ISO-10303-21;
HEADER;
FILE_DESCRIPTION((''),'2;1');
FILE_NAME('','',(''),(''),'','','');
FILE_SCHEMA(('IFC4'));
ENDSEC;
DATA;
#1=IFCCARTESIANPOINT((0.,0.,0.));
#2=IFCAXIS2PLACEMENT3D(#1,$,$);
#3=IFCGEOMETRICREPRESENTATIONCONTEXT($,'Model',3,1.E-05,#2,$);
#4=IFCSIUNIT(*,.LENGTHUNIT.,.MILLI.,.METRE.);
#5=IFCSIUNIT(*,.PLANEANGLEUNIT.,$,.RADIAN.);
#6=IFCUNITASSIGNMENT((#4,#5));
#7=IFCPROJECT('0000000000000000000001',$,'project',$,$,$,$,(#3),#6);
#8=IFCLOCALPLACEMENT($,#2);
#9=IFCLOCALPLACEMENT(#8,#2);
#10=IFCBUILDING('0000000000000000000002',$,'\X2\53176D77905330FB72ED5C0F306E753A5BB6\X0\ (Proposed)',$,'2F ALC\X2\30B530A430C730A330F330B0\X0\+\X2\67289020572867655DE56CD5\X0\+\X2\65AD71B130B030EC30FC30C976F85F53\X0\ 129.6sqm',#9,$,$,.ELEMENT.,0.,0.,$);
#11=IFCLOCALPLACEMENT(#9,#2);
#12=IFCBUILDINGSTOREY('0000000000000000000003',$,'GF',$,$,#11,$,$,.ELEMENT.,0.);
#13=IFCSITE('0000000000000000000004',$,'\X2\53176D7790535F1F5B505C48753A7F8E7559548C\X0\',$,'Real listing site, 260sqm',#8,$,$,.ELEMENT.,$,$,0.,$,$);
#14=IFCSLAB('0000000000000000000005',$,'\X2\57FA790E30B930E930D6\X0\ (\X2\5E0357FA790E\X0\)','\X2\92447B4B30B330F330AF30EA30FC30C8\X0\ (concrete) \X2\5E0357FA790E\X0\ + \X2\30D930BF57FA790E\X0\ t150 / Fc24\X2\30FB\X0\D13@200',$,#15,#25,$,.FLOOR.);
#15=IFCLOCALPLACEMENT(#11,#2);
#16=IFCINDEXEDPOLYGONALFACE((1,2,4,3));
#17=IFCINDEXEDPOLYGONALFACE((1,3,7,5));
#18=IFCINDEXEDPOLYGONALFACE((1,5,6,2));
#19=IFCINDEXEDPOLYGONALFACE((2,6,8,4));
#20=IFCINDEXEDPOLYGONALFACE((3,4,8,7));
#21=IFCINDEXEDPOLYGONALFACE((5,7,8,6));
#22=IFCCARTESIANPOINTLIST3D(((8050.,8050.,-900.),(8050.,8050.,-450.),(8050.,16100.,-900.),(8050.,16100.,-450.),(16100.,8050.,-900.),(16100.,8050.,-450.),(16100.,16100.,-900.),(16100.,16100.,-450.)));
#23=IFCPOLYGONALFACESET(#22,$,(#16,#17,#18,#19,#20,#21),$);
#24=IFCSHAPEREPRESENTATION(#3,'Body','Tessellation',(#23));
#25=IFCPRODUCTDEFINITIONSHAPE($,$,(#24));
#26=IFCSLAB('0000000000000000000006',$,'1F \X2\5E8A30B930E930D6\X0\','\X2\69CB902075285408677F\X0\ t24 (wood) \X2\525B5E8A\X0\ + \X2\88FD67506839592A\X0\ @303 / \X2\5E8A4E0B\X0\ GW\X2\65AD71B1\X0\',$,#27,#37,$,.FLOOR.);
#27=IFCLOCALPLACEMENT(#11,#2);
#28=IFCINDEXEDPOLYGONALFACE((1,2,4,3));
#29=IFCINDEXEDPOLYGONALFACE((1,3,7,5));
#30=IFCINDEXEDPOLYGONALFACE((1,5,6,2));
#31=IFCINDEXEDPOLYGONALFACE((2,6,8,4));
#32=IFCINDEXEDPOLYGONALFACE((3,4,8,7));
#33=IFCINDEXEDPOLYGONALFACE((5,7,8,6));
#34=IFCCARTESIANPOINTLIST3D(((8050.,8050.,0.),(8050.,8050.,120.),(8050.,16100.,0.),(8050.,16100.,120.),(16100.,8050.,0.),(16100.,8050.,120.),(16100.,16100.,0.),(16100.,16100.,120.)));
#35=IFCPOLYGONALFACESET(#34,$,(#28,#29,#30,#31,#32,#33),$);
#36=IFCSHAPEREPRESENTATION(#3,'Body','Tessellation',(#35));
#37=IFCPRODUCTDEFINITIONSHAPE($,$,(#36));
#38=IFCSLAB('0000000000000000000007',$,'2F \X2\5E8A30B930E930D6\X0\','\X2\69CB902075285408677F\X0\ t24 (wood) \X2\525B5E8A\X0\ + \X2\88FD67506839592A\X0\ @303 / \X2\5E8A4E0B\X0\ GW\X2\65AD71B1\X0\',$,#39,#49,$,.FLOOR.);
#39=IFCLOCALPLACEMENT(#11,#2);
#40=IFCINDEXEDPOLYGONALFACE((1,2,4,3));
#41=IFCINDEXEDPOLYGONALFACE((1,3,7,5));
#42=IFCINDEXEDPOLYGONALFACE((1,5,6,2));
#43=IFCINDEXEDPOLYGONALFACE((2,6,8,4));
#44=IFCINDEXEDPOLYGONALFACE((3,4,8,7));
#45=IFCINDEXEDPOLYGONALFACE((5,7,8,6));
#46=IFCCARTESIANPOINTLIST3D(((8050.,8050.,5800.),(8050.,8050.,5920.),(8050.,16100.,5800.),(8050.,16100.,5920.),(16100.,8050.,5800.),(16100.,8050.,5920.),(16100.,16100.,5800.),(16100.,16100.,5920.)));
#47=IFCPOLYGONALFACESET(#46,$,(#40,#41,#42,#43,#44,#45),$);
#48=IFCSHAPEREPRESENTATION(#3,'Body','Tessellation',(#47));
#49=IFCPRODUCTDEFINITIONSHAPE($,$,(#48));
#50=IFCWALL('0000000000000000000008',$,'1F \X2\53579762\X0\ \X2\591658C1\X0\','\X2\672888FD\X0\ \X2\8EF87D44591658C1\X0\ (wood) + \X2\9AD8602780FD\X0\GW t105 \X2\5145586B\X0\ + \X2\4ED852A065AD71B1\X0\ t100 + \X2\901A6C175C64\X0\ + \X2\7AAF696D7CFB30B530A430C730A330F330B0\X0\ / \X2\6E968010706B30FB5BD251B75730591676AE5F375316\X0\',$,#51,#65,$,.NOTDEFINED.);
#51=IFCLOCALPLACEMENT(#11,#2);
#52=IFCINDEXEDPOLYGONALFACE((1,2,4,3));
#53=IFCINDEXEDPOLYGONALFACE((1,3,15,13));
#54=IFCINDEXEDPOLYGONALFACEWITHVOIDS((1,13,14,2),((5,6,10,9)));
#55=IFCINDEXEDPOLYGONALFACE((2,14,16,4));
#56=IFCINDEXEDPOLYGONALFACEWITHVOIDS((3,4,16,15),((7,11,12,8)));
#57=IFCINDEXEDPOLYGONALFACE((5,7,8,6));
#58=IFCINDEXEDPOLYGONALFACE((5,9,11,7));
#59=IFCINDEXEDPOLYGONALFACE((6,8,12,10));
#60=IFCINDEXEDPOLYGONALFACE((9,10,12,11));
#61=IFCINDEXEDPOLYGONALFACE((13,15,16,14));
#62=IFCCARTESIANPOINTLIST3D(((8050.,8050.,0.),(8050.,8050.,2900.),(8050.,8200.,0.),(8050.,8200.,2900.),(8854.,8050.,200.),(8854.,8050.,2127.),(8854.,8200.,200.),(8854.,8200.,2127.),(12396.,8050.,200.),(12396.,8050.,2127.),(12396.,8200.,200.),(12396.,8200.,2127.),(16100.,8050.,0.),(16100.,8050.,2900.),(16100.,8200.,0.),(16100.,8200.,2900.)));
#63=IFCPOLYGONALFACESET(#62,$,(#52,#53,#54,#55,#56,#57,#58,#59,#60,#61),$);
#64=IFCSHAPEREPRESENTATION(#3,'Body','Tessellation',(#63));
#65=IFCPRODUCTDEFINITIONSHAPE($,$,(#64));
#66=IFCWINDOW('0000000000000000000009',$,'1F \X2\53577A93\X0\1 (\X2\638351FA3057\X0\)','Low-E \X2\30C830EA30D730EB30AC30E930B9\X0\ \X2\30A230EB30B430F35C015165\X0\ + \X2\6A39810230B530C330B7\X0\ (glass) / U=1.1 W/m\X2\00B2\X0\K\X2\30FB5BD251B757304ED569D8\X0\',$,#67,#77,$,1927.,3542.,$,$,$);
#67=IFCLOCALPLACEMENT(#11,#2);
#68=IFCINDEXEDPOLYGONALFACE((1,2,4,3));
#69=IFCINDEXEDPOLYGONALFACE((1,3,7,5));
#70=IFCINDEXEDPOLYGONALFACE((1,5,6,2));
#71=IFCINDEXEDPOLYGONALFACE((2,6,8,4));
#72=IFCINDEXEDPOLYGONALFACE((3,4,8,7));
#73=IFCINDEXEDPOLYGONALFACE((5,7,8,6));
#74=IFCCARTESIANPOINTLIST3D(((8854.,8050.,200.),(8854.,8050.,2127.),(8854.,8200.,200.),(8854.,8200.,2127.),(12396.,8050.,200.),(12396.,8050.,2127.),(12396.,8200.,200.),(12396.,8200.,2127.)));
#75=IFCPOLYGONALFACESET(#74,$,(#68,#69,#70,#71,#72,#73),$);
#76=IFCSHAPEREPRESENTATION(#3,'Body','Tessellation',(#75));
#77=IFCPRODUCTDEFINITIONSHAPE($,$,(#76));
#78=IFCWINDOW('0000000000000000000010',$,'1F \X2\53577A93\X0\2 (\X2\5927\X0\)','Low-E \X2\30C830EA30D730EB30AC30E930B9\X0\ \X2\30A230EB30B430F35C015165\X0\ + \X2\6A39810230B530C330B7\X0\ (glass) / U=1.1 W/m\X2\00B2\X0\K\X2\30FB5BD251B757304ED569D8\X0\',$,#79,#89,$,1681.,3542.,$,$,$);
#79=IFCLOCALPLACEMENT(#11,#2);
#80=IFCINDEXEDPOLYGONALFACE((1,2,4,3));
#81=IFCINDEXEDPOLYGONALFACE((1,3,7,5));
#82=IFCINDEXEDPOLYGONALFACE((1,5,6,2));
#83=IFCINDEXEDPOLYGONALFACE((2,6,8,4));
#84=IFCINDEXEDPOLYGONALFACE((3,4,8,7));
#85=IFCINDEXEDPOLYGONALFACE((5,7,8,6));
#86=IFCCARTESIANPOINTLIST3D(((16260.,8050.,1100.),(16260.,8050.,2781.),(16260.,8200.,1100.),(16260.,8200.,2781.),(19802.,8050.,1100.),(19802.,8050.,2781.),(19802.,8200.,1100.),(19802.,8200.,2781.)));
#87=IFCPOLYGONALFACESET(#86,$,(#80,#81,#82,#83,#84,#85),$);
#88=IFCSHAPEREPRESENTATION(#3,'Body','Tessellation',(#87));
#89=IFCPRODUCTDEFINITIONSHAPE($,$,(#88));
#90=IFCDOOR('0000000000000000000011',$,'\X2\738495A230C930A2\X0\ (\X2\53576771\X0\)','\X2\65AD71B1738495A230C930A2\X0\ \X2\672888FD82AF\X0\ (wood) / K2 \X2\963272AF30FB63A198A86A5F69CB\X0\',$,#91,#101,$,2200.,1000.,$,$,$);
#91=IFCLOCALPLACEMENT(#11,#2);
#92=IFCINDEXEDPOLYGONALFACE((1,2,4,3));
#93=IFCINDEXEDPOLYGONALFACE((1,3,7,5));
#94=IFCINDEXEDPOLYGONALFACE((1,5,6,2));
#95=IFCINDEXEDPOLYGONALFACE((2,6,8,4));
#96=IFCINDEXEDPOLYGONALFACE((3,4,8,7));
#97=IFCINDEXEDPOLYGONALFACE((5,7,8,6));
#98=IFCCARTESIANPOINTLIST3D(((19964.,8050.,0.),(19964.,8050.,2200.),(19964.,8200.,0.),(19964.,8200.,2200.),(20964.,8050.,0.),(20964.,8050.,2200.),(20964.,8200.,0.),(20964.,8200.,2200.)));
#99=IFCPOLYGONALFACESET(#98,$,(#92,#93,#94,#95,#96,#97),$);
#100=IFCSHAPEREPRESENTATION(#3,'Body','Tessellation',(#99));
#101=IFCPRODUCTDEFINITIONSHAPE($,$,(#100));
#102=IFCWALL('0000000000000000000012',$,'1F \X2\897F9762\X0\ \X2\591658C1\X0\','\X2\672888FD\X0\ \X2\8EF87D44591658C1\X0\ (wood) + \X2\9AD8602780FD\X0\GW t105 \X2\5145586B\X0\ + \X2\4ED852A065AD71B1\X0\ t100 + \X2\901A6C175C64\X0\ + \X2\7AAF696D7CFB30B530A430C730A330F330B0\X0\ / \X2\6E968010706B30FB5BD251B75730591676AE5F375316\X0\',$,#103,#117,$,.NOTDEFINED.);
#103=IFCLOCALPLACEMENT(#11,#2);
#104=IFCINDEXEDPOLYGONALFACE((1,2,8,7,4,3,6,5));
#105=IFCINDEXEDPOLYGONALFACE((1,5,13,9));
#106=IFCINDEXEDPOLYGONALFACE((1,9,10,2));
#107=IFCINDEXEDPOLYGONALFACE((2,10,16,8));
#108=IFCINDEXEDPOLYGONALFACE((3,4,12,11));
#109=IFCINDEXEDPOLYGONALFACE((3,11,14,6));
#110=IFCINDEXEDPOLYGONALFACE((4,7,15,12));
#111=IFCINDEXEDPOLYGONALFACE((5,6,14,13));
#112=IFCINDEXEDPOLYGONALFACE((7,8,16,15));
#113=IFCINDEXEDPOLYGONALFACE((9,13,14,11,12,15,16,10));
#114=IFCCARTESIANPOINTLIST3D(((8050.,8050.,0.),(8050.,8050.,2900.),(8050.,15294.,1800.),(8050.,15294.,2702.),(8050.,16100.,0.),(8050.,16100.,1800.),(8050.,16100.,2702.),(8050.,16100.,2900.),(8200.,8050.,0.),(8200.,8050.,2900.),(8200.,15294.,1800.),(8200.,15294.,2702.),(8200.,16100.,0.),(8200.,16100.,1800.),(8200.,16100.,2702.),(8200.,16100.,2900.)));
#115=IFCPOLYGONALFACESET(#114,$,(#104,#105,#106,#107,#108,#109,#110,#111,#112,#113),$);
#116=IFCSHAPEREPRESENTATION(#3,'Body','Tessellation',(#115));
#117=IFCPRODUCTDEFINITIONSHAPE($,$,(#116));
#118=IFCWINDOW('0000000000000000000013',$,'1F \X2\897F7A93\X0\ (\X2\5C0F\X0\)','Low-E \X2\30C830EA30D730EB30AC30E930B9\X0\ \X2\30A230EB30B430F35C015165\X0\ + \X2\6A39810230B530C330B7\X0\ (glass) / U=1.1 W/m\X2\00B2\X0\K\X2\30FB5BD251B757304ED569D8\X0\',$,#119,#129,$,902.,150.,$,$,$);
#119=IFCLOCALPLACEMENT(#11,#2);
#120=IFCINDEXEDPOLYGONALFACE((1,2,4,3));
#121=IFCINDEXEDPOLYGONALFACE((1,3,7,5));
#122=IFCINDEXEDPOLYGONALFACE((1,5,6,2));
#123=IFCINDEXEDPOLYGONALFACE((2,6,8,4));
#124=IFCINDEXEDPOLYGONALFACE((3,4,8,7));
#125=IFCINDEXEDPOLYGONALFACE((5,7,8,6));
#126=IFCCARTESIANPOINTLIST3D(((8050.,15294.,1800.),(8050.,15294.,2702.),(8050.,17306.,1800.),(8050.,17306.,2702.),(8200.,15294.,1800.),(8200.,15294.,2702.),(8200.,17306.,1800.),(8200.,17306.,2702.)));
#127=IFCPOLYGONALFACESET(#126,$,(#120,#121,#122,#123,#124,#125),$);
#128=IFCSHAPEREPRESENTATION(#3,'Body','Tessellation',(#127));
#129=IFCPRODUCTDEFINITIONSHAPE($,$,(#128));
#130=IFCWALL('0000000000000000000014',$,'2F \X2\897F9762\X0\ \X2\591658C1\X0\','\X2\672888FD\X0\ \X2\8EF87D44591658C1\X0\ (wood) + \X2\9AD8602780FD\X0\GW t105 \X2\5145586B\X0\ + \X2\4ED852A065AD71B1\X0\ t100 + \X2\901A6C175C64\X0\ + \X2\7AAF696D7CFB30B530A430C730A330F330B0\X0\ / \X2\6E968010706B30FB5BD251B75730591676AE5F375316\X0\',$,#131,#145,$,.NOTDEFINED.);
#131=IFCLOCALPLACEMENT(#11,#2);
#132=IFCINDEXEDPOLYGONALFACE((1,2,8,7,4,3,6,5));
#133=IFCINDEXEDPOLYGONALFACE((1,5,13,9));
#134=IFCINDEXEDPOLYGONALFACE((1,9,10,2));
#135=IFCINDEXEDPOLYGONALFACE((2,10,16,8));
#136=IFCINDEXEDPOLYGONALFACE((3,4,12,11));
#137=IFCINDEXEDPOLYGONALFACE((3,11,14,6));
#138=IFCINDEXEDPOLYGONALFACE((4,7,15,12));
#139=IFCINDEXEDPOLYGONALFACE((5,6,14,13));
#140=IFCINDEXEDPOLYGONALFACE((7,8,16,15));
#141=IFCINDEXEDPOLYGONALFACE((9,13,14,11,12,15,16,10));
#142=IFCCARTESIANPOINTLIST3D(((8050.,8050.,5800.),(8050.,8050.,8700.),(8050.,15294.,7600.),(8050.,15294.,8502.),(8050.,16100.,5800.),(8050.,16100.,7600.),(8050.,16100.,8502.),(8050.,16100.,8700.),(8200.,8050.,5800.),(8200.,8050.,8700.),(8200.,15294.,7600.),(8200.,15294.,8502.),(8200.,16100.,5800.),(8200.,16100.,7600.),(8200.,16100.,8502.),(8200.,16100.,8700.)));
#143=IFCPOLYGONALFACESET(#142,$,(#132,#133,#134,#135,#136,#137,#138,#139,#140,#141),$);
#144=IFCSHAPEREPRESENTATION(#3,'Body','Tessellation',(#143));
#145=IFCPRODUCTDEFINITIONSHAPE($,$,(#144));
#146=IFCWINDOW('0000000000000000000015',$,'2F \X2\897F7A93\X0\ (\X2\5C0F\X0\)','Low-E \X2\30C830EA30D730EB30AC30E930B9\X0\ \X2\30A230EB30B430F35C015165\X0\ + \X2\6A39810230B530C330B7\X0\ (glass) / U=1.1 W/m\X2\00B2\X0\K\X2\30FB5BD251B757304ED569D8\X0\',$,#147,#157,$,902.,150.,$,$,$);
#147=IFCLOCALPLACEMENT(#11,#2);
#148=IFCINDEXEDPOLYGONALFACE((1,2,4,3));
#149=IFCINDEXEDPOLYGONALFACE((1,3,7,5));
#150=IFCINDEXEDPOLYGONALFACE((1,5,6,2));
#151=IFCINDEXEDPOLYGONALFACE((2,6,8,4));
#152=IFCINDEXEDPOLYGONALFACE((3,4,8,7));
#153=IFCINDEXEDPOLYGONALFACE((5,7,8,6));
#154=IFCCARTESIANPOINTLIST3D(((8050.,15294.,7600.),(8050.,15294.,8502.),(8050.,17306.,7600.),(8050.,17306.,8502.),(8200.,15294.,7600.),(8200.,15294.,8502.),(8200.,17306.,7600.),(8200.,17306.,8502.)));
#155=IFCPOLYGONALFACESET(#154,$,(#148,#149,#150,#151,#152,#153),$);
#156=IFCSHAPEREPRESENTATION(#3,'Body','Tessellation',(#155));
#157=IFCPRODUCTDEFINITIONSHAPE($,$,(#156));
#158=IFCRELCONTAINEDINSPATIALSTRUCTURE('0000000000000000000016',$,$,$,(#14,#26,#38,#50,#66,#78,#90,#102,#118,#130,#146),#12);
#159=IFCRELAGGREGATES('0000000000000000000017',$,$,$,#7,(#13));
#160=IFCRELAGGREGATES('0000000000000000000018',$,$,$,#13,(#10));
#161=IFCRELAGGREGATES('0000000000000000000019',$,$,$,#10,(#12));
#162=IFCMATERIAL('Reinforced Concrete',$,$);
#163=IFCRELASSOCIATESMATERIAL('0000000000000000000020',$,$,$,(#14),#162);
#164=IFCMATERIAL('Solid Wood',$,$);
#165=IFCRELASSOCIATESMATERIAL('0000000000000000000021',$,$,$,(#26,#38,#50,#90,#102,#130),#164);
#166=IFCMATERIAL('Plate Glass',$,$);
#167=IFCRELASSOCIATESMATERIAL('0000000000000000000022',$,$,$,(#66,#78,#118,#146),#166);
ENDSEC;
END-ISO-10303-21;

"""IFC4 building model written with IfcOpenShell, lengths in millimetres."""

from ifc_helpers import new_model, si_unit, frame, frame_2d, origin, place, context, project, spatial, rectangle, extrude, material, element, fill, save


model = new_model("IFC4")

# Units and contexts
model_context = context("Model", 3, precision=1e-05, world=origin())
ifc_project = project(units=[si_unit("LENGTHUNIT", "METRE", prefix="MILLI"), si_unit("PLANEANGLEUNIT", "RADIAN")], contexts=[model_context])

# Site, building, storey
site_placement = place(None, origin())
site = spatial("IfcSite", under=ifc_project, at=site_placement, Name="北海道弟子屈町美留和", ObjectType="Real listing site, 260sqm", CompositionType="ELEMENT", RefElevation=0.0)
building_placement = place(site_placement, origin())
building = spatial("IfcBuilding", under=site, at=building_placement, Name="北海道・狭小の町家 (Proposed)", ObjectType="2F ALCサイディング+木造在来工法+断熱グレード相当 129.6sqm", CompositionType="ELEMENT", ElevationOfRefHeight=0.0, ElevationOfTerrain=0.0)
storey_placement = place(building_placement, origin())
storey = spatial("IfcBuildingStorey", under=building, at=storey_placement, Name="GF", CompositionType="ELEMENT", Elevation=0.0)

# Shared definitions
ifc_material_1 = material(Name="Solid Wood")

# Slabs
ifc_material_2 = material(Name="Reinforced Concrete")
slab_1_placement = place(storey_placement, frame((4025.0, 4025.0, -450.0)))
element("IfcSlab", 1, at=slab_1_placement, inside=storey, material=ifc_material_2, Name="基礎スラブ (布基礎)", Description="鉄筋コンクリート (concrete) 布基礎 + ベタ基礎 t150 / Fc24・D13@200", PredefinedType="FLOOR", context=model_context, shape_type="SweptSolid", body=[
    extrude(rectangle(XDim=8050.0, YDim=8050.0, at=frame_2d((4025.0, 4025.0))), frame((4025.0, 4025.0, -450.0)), (0.0, 0.0, 1.0), 450.0),
])
slab_2_placement = place(storey_placement, frame((4025.0, 4025.0, 0.0)))
element("IfcSlab", 2, at=slab_2_placement, inside=storey, material=ifc_material_1, Name="1F 床スラブ", Description="構造用合板 t24 (wood) 剛床 + 製材根太 @303 / 床下 GW断熱", PredefinedType="FLOOR", context=model_context, shape_type="SweptSolid", body=[
    extrude(rectangle(XDim=8050.0, YDim=8050.0, at=frame_2d((4025.0, 4025.0))), frame((4025.0, 4025.0, 0.0)), (0.0, 0.0, 1.0), 120.0),
])
slab_3_placement = place(storey_placement, frame((4025.0, 4025.0, 2900.0)))
element("IfcSlab", 3, at=slab_3_placement, inside=storey, material=ifc_material_1, Name="2F 床スラブ", Description="構造用合板 t24 (wood) 剛床 + 製材根太 @303 / 床下 GW断熱", PredefinedType="FLOOR", context=model_context, shape_type="SweptSolid", body=[
    extrude(rectangle(XDim=8050.0, YDim=8050.0, at=frame_2d((4025.0, 4025.0))), frame((4025.0, 4025.0, 2900.0)), (0.0, 0.0, 1.0), 120.0),
])

# Wall, openings, windows, door
wall_1_placement = place(storey_placement, frame((4025.0, 4025.0, 0.0)))
wall_1 = element("IfcWall", 4, at=wall_1_placement, inside=storey, material=ifc_material_1, Name="1F 南面 外壁", Description="木製 軸組外壁 (wood) + 高性能GW t105 充填 + 付加断熱 t100 + 通気層 + 窯業系サイディング / 準耐火・寒冷地外皮強化", PredefinedType="NOTDEFINED", context=model_context, shape_type="SweptSolid", body=[
    extrude(rectangle(XDim=8050.0, YDim=150.0, at=frame_2d((4025.0, 75.0))), frame((4025.0, 4025.0, 0.0)), (0.0, 0.0, 1.0), 2900.0),
])
opening_1_placement = place(storey_placement, frame((4427.0, 4025.0, 100.0)))
opening_1 = element("IfcOpeningElement", 5, at=opening_1_placement, cuts=wall_1, PredefinedType="NOTDEFINED", context=model_context, shape_type="SweptSolid", body=[
    extrude(rectangle(XDim=3542.0, YDim=150.0, at=frame_2d((1771.0, 75.0))), frame((4427.0, 4025.0, 100.0)), (0.0, 0.0, 1.0), 1927.0),
])
opening_2_placement = place(storey_placement, frame((8130.0, 4025.0, 550.0)))
opening_2 = element("IfcOpeningElement", 6, at=opening_2_placement, cuts=wall_1, PredefinedType="NOTDEFINED", context=model_context, shape_type="SweptSolid", body=[
    extrude(rectangle(XDim=3542.0, YDim=150.0, at=frame_2d((1771.0, 75.0))), frame((8130.0, 4025.0, 550.0)), (0.0, 0.0, 1.0), 1681.0),
])
opening_3_placement = place(storey_placement, frame((9982.0, 4025.0, 0.0)))
opening_3 = element("IfcOpeningElement", 7, at=opening_3_placement, cuts=wall_1, PredefinedType="NOTDEFINED", context=model_context, shape_type="SweptSolid", body=[
    extrude(rectangle(XDim=1000.0, YDim=150.0, at=frame_2d((500.0, 75.0))), frame((9982.0, 4025.0, 0.0)), (0.0, 0.0, 1.0), 2200.0),
])
ifc_material_3 = material(Name="Plate Glass")
window_1_placement = place(storey_placement, frame((4427.0, 4025.0, 100.0)))
window_1 = element("IfcWindow", 8, at=window_1_placement, inside=storey, material=ifc_material_3, Name="1F 南窓1 (掃出し)", Description="Low-E トリプルガラス アルゴン封入 + 樹脂サッシ (glass) / U=1.1 W/m²K・寒冷地仕様", OverallHeight=1927.0, OverallWidth=3542.0, context=model_context, shape_type="SweptSolid", body=[
    extrude(rectangle(XDim=3542.0, YDim=150.0, at=frame_2d((1771.0, 75.0))), frame((4427.0, 4025.0, 100.0)), (0.0, 0.0, 1.0), 1927.0),
])
fill(opening_1, window_1)
window_2_placement = place(storey_placement, frame((8130.0, 4025.0, 550.0)))
window_2 = element("IfcWindow", 9, at=window_2_placement, inside=storey, material=ifc_material_3, Name="1F 南窓2 (大)", Description="Low-E トリプルガラス アルゴン封入 + 樹脂サッシ (glass) / U=1.1 W/m²K・寒冷地仕様", OverallHeight=1681.0, OverallWidth=3542.0, context=model_context, shape_type="SweptSolid", body=[
    extrude(rectangle(XDim=3542.0, YDim=150.0, at=frame_2d((1771.0, 75.0))), frame((8130.0, 4025.0, 550.0)), (0.0, 0.0, 1.0), 1681.0),
])
fill(opening_2, window_2)
door_placement = place(storey_placement, frame((9982.0, 4025.0, 0.0)))
door = element("IfcDoor", 10, at=door_placement, inside=storey, material=ifc_material_1, Name="玄関ドア (南東)", Description="断熱玄関ドア 木製芯 (wood) / K2 防犯・採風機構", OverallHeight=2200.0, OverallWidth=1000.0, context=model_context, shape_type="SweptSolid", body=[
    extrude(rectangle(XDim=1000.0, YDim=150.0, at=frame_2d((500.0, 75.0))), frame((9982.0, 4025.0, 0.0)), (0.0, 0.0, 1.0), 2200.0),
])
fill(opening_3, door)

# Wall, opening, window
wall_2_placement = place(storey_placement, frame((4025.0, 4025.0, 0.0)))
wall_2 = element("IfcWall", 11, at=wall_2_placement, inside=storey, material=ifc_material_1, Name="1F 西面 外壁", Description="木製 軸組外壁 (wood) + 高性能GW t105 充填 + 付加断熱 t100 + 通気層 + 窯業系サイディング / 準耐火・寒冷地外皮強化", PredefinedType="NOTDEFINED", context=model_context, shape_type="SweptSolid", body=[
    extrude(rectangle(XDim=150.0, YDim=8050.0, at=frame_2d((75.0, 4025.0))), frame((4025.0, 4025.0, 0.0)), (0.0, 0.0, 1.0), 2900.0),
])
opening_4_placement = place(storey_placement, frame((4025.0, 7647.0, 900.0)))
opening_4 = element("IfcOpeningElement", 12, at=opening_4_placement, cuts=wall_2, PredefinedType="NOTDEFINED", context=model_context, shape_type="SweptSolid", body=[
    extrude(rectangle(XDim=150.0, YDim=2012.0, at=frame_2d((75.0, 1006.0))), frame((4025.0, 7647.0, 900.0)), (0.0, 0.0, 1.0), 902.0),
])
window_3_placement = place(storey_placement, frame((4025.0, 7647.0, 900.0)))
window_3 = element("IfcWindow", 13, at=window_3_placement, inside=storey, material=ifc_material_3, Name="1F 西窓 (小)", Description="Low-E トリプルガラス アルゴン封入 + 樹脂サッシ (glass) / U=1.1 W/m²K・寒冷地仕様", OverallHeight=902.0, OverallWidth=150.0, context=model_context, shape_type="SweptSolid", body=[
    extrude(rectangle(XDim=150.0, YDim=2012.0, at=frame_2d((75.0, 1006.0))), frame((4025.0, 7647.0, 900.0)), (0.0, 0.0, 1.0), 902.0),
])
fill(opening_4, window_3)

# Wall, opening, window
wall_3_placement = place(storey_placement, frame((4025.0, 4025.0, 2900.0)))
wall_3 = element("IfcWall", 14, at=wall_3_placement, inside=storey, material=ifc_material_1, Name="2F 西面 外壁", Description="木製 軸組外壁 (wood) + 高性能GW t105 充填 + 付加断熱 t100 + 通気層 + 窯業系サイディング / 準耐火・寒冷地外皮強化", PredefinedType="NOTDEFINED", context=model_context, shape_type="SweptSolid", body=[
    extrude(rectangle(XDim=150.0, YDim=8050.0, at=frame_2d((75.0, 4025.0))), frame((4025.0, 4025.0, 2900.0)), (0.0, 0.0, 1.0), 2900.0),
])
opening_5_placement = place(storey_placement, frame((4025.0, 7647.0, 3800.0)))
opening_5 = element("IfcOpeningElement", 15, at=opening_5_placement, cuts=wall_3, PredefinedType="NOTDEFINED", context=model_context, shape_type="SweptSolid", body=[
    extrude(rectangle(XDim=150.0, YDim=2012.0, at=frame_2d((75.0, 1006.0))), frame((4025.0, 7647.0, 3800.0)), (0.0, 0.0, 1.0), 902.0),
])
window_4_placement = place(storey_placement, frame((4025.0, 7647.0, 3800.0)))
window_4 = element("IfcWindow", 16, at=window_4_placement, inside=storey, material=ifc_material_3, Name="2F 西窓 (小)", Description="Low-E トリプルガラス アルゴン封入 + 樹脂サッシ (glass) / U=1.1 W/m²K・寒冷地仕様", OverallHeight=902.0, OverallWidth=150.0, context=model_context, shape_type="SweptSolid", body=[
    extrude(rectangle(XDim=150.0, YDim=2012.0, at=frame_2d((75.0, 1006.0))), frame((4025.0, 7647.0, 3800.0)), (0.0, 0.0, 1.0), 902.0),
])
fill(opening_5, window_4)

save(model, "model.ifc")
